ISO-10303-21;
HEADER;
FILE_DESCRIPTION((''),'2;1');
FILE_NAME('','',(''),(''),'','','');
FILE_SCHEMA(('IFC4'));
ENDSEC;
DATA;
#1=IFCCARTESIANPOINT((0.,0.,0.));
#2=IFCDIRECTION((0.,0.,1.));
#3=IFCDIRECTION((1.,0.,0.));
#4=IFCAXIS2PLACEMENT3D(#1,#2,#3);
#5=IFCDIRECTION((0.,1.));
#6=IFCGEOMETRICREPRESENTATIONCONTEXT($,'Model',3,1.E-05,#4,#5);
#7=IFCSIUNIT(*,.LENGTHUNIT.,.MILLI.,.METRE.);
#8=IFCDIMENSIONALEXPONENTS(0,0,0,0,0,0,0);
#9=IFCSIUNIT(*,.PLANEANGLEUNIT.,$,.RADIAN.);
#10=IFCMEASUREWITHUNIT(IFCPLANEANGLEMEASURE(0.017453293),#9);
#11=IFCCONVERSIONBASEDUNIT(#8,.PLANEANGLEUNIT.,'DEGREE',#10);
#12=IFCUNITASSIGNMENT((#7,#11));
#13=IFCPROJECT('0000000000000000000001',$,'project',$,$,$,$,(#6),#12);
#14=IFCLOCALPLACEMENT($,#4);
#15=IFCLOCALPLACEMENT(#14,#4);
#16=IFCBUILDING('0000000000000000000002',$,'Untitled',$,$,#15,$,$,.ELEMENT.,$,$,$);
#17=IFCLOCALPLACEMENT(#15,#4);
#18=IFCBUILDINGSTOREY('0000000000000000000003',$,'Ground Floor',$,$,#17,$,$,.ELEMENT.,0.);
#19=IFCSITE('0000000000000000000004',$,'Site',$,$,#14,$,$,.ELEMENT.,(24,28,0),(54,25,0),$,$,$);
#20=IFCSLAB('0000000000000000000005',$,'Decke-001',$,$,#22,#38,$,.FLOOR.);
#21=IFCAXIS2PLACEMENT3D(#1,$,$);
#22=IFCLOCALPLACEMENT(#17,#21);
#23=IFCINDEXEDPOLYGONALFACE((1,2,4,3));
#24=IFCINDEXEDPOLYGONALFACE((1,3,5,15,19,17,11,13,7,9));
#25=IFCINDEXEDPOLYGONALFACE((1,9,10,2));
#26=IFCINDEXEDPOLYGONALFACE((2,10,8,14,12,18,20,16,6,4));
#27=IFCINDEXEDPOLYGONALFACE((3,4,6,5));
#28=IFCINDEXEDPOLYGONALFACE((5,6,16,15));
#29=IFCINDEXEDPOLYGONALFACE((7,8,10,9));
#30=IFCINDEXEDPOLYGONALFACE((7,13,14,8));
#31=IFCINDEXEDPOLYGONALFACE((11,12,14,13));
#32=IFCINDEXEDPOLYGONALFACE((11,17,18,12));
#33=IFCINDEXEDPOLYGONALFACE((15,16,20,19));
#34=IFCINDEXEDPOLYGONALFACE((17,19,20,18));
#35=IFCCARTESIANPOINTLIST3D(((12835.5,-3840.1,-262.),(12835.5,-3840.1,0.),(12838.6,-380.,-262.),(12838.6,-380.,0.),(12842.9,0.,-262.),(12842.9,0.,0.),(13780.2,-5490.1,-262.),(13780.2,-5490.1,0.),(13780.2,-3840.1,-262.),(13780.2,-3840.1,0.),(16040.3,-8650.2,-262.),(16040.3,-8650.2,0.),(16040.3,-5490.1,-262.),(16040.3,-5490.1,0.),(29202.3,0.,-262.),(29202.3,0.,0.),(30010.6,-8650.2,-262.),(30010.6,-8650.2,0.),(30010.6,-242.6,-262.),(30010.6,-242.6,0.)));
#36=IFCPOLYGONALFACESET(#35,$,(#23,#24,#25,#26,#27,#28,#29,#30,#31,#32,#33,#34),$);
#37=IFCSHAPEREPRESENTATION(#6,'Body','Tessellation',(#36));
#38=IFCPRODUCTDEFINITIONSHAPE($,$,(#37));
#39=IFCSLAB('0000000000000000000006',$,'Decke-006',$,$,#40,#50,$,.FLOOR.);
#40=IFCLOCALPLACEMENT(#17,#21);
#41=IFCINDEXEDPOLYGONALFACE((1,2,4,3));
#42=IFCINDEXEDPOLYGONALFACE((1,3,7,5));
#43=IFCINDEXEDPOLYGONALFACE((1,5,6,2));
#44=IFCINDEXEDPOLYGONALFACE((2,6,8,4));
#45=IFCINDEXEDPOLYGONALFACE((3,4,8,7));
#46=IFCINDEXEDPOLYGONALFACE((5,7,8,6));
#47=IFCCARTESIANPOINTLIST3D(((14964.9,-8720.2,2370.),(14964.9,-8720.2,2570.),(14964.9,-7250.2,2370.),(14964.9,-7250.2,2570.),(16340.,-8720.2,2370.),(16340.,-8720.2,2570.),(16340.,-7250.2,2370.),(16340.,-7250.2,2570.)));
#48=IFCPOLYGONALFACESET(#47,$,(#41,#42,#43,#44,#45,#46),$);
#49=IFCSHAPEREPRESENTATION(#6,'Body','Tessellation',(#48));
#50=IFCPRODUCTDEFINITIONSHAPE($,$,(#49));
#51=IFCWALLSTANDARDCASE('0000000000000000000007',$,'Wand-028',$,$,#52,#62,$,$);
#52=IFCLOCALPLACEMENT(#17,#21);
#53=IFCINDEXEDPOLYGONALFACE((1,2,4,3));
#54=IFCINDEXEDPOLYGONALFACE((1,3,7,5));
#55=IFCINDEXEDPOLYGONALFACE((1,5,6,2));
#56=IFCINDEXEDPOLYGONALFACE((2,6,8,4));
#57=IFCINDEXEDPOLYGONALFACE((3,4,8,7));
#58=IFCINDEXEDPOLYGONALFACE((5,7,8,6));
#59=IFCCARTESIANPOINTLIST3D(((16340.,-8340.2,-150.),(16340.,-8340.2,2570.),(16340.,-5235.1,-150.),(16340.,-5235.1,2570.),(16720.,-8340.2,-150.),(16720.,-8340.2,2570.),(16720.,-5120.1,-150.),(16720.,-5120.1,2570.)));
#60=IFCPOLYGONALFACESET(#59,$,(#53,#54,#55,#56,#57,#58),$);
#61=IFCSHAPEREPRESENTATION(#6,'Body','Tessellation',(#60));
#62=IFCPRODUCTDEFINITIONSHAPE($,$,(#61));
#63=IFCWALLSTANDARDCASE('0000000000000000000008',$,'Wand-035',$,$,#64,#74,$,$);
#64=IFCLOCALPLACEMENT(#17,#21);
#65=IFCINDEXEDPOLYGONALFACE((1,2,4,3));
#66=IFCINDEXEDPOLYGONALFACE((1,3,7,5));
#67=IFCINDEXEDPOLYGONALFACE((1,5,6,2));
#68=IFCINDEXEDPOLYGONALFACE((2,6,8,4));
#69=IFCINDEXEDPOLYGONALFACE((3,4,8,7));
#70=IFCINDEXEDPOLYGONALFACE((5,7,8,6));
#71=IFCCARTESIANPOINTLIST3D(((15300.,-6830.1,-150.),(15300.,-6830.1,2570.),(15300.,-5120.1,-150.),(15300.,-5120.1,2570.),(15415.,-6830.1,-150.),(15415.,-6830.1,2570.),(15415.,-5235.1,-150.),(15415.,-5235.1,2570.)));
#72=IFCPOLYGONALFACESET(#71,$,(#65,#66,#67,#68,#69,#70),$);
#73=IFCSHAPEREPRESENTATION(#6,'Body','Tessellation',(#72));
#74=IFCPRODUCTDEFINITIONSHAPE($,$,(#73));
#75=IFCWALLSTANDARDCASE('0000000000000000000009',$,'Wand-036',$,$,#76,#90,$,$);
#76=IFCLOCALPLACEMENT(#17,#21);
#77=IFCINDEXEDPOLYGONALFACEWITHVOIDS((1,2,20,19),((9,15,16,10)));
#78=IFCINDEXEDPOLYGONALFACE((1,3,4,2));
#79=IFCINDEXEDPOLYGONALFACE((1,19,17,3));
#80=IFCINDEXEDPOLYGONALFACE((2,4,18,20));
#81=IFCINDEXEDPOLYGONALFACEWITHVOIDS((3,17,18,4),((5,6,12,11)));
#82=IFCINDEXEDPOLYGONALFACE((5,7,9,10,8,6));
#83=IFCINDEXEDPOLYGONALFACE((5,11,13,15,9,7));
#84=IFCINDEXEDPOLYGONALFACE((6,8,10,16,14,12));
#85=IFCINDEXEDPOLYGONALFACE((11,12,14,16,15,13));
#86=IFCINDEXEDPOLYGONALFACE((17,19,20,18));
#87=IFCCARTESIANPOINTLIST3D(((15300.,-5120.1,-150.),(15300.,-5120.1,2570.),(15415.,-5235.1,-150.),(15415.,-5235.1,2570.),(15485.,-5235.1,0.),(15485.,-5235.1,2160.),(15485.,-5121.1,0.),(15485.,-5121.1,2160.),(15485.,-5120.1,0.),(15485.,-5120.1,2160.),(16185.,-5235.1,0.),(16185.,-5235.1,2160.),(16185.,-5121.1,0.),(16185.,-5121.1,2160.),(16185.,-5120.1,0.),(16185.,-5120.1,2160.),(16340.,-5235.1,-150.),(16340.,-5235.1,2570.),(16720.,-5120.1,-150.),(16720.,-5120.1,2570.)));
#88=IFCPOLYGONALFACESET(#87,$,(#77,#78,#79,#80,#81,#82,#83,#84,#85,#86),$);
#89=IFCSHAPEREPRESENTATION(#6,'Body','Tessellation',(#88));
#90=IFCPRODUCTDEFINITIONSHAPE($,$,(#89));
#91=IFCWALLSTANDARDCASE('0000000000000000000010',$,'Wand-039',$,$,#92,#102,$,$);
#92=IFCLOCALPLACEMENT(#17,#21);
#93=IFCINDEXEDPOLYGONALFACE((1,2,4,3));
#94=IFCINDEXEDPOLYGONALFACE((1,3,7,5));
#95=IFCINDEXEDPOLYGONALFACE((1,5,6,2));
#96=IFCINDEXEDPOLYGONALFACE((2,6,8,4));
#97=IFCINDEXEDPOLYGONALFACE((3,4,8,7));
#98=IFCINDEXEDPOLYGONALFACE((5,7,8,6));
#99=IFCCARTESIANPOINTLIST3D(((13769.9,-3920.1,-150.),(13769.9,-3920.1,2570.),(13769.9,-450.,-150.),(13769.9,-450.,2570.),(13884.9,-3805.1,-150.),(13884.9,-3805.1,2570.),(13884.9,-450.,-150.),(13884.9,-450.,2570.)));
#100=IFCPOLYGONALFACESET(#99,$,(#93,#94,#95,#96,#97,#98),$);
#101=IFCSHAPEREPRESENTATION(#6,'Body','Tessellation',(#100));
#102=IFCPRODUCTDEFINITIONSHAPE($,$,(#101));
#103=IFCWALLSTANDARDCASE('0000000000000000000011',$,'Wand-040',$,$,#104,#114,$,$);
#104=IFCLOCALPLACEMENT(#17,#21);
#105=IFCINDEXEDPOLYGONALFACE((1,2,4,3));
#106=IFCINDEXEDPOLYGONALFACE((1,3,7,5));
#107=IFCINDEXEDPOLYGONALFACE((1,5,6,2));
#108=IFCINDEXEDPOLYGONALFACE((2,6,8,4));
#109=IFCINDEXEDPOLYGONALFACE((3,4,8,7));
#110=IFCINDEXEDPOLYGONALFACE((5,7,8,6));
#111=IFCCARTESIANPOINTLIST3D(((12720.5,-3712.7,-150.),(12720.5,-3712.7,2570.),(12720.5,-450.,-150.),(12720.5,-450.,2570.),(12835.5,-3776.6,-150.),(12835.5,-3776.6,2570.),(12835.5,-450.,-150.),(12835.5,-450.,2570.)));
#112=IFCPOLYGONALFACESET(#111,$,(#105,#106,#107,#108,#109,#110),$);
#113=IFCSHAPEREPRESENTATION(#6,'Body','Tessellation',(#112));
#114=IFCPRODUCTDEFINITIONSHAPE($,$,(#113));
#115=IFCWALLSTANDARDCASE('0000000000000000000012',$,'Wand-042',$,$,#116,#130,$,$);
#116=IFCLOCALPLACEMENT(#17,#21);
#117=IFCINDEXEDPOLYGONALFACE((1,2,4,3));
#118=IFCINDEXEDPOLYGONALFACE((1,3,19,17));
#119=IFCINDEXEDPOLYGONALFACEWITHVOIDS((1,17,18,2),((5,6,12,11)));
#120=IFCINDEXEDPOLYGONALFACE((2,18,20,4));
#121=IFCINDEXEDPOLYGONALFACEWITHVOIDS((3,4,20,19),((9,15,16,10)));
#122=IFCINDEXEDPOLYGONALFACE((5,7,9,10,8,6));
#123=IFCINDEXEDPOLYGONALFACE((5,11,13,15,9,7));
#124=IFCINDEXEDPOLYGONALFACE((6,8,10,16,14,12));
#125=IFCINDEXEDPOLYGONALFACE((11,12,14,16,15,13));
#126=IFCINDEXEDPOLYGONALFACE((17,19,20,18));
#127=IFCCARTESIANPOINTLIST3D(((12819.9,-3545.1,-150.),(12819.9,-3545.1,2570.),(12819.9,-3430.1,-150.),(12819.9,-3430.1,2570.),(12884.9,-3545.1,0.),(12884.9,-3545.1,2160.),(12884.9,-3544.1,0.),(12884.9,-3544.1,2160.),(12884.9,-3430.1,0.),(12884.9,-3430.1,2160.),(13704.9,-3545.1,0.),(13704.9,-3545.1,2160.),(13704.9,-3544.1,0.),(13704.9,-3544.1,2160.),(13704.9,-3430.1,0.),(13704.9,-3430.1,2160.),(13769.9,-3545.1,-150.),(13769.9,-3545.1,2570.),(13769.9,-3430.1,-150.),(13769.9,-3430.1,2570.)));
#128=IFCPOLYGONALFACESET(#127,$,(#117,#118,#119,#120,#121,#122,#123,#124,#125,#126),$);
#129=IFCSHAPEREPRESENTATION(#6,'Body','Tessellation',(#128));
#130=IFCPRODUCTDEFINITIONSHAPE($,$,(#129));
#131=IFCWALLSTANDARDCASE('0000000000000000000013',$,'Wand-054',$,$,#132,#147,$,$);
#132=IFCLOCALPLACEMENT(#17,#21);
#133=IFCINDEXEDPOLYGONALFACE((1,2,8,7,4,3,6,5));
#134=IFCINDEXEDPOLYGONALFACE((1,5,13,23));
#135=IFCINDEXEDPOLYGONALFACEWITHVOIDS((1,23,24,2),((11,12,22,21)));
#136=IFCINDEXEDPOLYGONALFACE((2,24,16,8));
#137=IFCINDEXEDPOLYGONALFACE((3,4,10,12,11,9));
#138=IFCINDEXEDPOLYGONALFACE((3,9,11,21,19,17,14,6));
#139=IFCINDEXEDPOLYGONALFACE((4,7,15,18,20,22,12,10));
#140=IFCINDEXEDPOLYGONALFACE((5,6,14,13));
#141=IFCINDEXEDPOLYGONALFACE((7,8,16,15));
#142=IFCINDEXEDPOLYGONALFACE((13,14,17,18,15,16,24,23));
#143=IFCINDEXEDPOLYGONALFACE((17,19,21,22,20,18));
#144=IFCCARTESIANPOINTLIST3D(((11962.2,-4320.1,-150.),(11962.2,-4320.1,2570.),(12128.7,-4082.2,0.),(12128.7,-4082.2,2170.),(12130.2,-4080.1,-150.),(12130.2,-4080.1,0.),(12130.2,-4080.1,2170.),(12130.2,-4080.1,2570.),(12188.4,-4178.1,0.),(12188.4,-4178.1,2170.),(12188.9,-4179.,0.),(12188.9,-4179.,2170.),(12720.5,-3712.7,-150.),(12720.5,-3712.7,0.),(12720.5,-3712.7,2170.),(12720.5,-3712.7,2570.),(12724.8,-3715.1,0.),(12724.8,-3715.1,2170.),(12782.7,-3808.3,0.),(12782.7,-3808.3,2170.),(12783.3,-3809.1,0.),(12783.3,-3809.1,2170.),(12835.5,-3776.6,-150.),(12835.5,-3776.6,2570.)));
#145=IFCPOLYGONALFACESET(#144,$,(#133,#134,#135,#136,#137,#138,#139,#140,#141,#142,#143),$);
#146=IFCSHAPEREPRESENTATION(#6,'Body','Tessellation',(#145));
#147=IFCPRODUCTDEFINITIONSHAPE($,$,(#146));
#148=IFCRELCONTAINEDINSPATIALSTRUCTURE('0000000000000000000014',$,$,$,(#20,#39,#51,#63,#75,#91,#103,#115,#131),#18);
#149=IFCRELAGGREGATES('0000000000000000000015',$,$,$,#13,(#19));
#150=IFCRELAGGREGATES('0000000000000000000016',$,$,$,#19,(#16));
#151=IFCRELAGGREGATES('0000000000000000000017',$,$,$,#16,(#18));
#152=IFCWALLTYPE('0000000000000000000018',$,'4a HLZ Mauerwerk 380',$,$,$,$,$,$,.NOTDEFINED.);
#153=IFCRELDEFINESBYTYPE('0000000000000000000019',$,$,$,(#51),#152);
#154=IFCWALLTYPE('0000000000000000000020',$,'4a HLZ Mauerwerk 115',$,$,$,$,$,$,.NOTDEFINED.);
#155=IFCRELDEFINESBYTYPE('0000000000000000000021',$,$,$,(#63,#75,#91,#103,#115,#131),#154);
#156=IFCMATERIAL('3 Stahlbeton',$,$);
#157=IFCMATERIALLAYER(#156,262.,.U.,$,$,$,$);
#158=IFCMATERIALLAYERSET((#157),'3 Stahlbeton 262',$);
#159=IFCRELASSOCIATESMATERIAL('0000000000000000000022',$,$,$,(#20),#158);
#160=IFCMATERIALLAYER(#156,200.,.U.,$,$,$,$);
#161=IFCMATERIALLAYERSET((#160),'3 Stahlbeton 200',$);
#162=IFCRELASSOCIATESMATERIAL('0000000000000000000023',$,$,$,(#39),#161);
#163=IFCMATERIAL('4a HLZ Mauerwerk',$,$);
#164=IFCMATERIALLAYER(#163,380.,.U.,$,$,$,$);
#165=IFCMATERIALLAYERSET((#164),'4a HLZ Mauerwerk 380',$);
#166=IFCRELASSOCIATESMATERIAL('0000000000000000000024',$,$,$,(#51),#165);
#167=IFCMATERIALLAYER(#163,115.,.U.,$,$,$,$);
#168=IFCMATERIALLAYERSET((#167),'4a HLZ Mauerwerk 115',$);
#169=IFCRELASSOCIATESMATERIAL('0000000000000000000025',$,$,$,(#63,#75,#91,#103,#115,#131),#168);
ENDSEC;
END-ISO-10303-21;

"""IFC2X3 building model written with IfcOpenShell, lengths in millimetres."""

from ifc_helpers import new_model, entity, si_unit, converted_unit, direction, frame, origin_with_axes, origin_2d_with_axis, place, context, project, spatial, polyline, rectangle, outline, extrude, material, layer, layer_set, layer_usage, type_object, element, save


model = new_model("IFC2X3")

# Units and contexts
model_context = context("Model", 3, precision=1e-05, world=origin_with_axes(), true_north=direction((0.0, 1.0)))
ifc_project = project(units=[si_unit("LENGTHUNIT", "METRE", prefix="MILLI"), converted_unit("PLANEANGLEUNIT", "DEGREE", entity("IfcPlaneAngleMeasure", 0.017453293), si_unit("PLANEANGLEUNIT", "RADIAN"), dimensions=[0, 0, 0, 0, 0, 0, 0])], contexts=[model_context])

# Site, building, storey
site_placement = place(None, origin_with_axes())
site = spatial("IfcSite", under=ifc_project, at=site_placement, Name="Site", CompositionType="ELEMENT", RefLatitude=(24, 28, 0), RefLongitude=(54, 25, 0))
building_placement = place(site_placement, origin_with_axes())
building = spatial("IfcBuilding", under=site, at=building_placement, Name="Untitled", CompositionType="ELEMENT")
storey_placement = place(building_placement, origin_with_axes())
storey = spatial("IfcBuildingStorey", under=building, at=storey_placement, Name="Ground Floor", CompositionType="ELEMENT", Elevation=0.0)

# Slabs
ifc_material_1 = material(Name="3 Stahlbeton")
ifc_layer_1 = layer(ifc_material_1, 262.0, ventilated="UNKNOWN")
ifc_layer_set_1 = layer_set([ifc_layer_1], Name="3 Stahlbeton 262")
ifc_layer_usage_1 = layer_usage(ifc_layer_set_1, "AXIS3", "NEGATIVE", 262.0)
slab_1_placement = place(storey_placement, frame((12842.9, 0.0, -262.0), z_axis=(0.0, 0.0, 1.0), x_axis=(1.0, 0.0, 0.0)))
element("IfcSlab", 1, at=slab_1_placement, inside=storey, material=ifc_layer_usage_1, Name="Decke-001", PredefinedType="FLOOR", context=model_context, shape_type="SweptSolid", body=[
    extrude(outline(polyline([(0.0, 0.0), (-4.3, -380.0), (-7.4, -3840.1), (937.3, -3840.1), (937.3, -5490.1), (3197.4, -5490.1), (3197.4, -8650.2), (17167.7, -8650.2), (17167.7, -242.6), (16359.4, 0.0), (0.0, 0.0)])), origin_with_axes(), (0.0, 0.0, 1.0), 262.0),
])
ifc_layer_2 = layer(ifc_material_1, 200.0, ventilated="UNKNOWN")
ifc_layer_set_2 = layer_set([ifc_layer_2], Name="3 Stahlbeton 200")
ifc_layer_usage_2 = layer_usage(ifc_layer_set_2, "AXIS3", "NEGATIVE", 200.0)
slab_2_placement = place(storey_placement, frame((14964.9, -7250.2, 2370.0), z_axis=(0.0, 0.0, 1.0), x_axis=(1.0, 0.0, 0.0)))
element("IfcSlab", 2, at=slab_2_placement, inside=storey, material=ifc_layer_usage_2, Name="Decke-006", PredefinedType="FLOOR", context=model_context, shape_type="SweptSolid", body=[
    extrude(outline(polyline([(0.0, 0.0), (0.0, -1470.0), (1375.1, -1470.0), (1375.1, 0.0), (0.0, 0.0)])), origin_with_axes(), (0.0, 0.0, 1.0), 200.0),
])

# Shared definitions
ifc_material_2 = material(Name="4a HLZ Mauerwerk")
ifc_layer_3 = layer(ifc_material_2, 380.0, ventilated="UNKNOWN")
ifc_layer_set_3 = layer_set([ifc_layer_3], Name="4a HLZ Mauerwerk 380")
wall_type_1 = type_object("IfcWallType", Name="4a HLZ Mauerwerk 380", PredefinedType="NOTDEFINED")

# Walls
ifc_layer_usage_3 = layer_usage(ifc_layer_set_3, "AXIS2", "NEGATIVE", 0.0)
wall_1_placement = place(storey_placement, frame((16340.0, -8720.2, -150.0), z_axis=(0.0, 0.0, 1.0), x_axis=(0.0, 1.0, 0.0)))
element("IfcWallStandardCase", 3, at=wall_1_placement, inside=storey, type_object=wall_type_1, material=ifc_layer_usage_3, Name="Wand-028", context=model_context, shape_type="SweptSolid", body=[
    extrude(outline(polyline([(380.0, -380.0), (3600.1, -380.0), (3485.1, 0.0), (380.0, 0.0), (380.0, -380.0)])), origin_with_axes(), (0.0, 0.0, 1.0), 2720.0),
])
ifc_layer_4 = layer(ifc_material_2, 115.0, ventilated="UNKNOWN")
ifc_layer_set_4 = layer_set([ifc_layer_4], Name="4a HLZ Mauerwerk 115")
ifc_layer_usage_4 = layer_usage(ifc_layer_set_4, "AXIS2", "NEGATIVE", 0.0)
wall_type_2 = type_object("IfcWallType", Name="4a HLZ Mauerwerk 115", PredefinedType="NOTDEFINED")
wall_2_placement = place(storey_placement, frame((15300.0, -6830.1, -150.0), z_axis=(0.0, 0.0, 1.0), x_axis=(0.0, 1.0, 0.0)))
element("IfcWallStandardCase", 4, at=wall_2_placement, inside=storey, type_object=wall_type_2, material=ifc_layer_usage_4, Name="Wand-035", context=model_context, shape_type="SweptSolid", body=[
    extrude(outline(polyline([(0.0, -115.0), (1595.0, -115.0), (1710.0, 0.0), (0.0, 0.0), (0.0, -115.0)])), origin_with_axes(), (0.0, 0.0, 1.0), 2720.0),
])

# Wall, opening
ifc_layer_usage_5 = layer_usage(ifc_layer_set_4, "AXIS2", "NEGATIVE", 0.0)
wall_3_placement = place(storey_placement, frame((15300.0, -5120.1, -150.0), z_axis=(0.0, 0.0, 1.0), x_axis=(1.0, 0.0, 0.0)))
wall_3 = element("IfcWallStandardCase", 5, at=wall_3_placement, inside=storey, type_object=wall_type_2, material=ifc_layer_usage_5, Name="Wand-036", context=model_context, shape_type="SweptSolid", body=[
    extrude(outline(polyline([(115.0, -115.0), (1040.0, -115.0), (1420.0, 0.0), (0.0, 0.0), (115.0, -115.0)])), origin_with_axes(), (0.0, 0.0, 1.0), 2720.0),
])
opening_1_placement = place(wall_3_placement, frame((535.0, 0.0, 150.0), z_axis=(0.0, 0.0, 1.0), x_axis=(1.0, 0.0, 0.0)))
element("IfcOpeningElement", 6, at=opening_1_placement, cuts=wall_3, context=model_context, shape_type="SweptSolid", body=[
    extrude(rectangle(XDim=700.0, YDim=2160.0, at=origin_2d_with_axis()), frame((0.0, 231.0, 1080.0), z_axis=(0.0, -1.0, 0.0), x_axis=(1.0, 0.0, 0.0)), (0.0, 0.0, 1.0), 232.0),
    extrude(rectangle(XDim=700.0, YDim=2160.0, at=origin_2d_with_axis()), frame((0.0, -231.0, 1080.0), z_axis=(0.0, 1.0, 0.0), x_axis=(1.0, 0.0, 0.0)), (0.0, 0.0, 1.0), 232.0),
])

# Walls
ifc_layer_usage_6 = layer_usage(ifc_layer_set_4, "AXIS2", "NEGATIVE", 0.0)
wall_4_placement = place(storey_placement, frame((13769.9, -3920.1, -150.0), z_axis=(0.0, 0.0, 1.0), x_axis=(0.0, 1.0, 0.0)))
element("IfcWallStandardCase", 7, at=wall_4_placement, inside=storey, type_object=wall_type_2, material=ifc_layer_usage_6, Name="Wand-039", context=model_context, shape_type="SweptSolid", body=[
    extrude(outline(polyline([(115.0, -115.0), (3470.1, -115.0), (3470.1, 0.0), (0.0, 0.0), (115.0, -115.0)])), origin_with_axes(), (0.0, 0.0, 1.0), 2720.0),
])
ifc_layer_usage_7 = layer_usage(ifc_layer_set_4, "AXIS2", "POSITIVE", 0.0)
wall_5_placement = place(storey_placement, frame((12720.5, -450.0, -150.0), z_axis=(0.0, 0.0, 1.0), x_axis=(0.0, -1.0, 0.0)))
element("IfcWallStandardCase", 8, at=wall_5_placement, inside=storey, type_object=wall_type_2, material=ifc_layer_usage_7, Name="Wand-040", context=model_context, shape_type="SweptSolid", body=[
    extrude(outline(polyline([(0.0, 0.0), (3262.7, 0.0), (3326.6, 115.0), (0.0, 115.0), (0.0, 0.0)])), origin_with_axes(), (0.0, 0.0, 1.0), 2720.0),
])

# Walls, openings
ifc_layer_usage_8 = layer_usage(ifc_layer_set_4, "AXIS2", "NEGATIVE", 0.0)
wall_6_placement = place(storey_placement, frame((12819.9, -3430.1, -150.0), z_axis=(0.0, 0.0, 1.0), x_axis=(1.0, 0.0, 0.0)))
wall_6 = element("IfcWallStandardCase", 9, at=wall_6_placement, inside=storey, type_object=wall_type_2, material=ifc_layer_usage_8, Name="Wand-042", context=model_context, shape_type="SweptSolid", body=[
    extrude(outline(polyline([(0.0, -115.0), (950.0, -115.0), (950.0, 0.0), (0.0, 0.0), (0.0, -115.0)])), origin_with_axes(), (0.0, 0.0, 1.0), 2720.0),
])
opening_2_placement = place(wall_6_placement, frame((475.0, 0.0, 150.0), z_axis=(0.0, 0.0, 1.0), x_axis=(1.0, 0.0, 0.0)))
element("IfcOpeningElement", 10, at=opening_2_placement, cuts=wall_6, context=model_context, shape_type="SweptSolid", body=[
    extrude(rectangle(XDim=820.0, YDim=2160.0, at=origin_2d_with_axis()), frame((0.0, -346.0, 1080.0), z_axis=(0.0, 1.0, 0.0), x_axis=(1.0, 0.0, 0.0)), (0.0, 0.0, 1.0), 232.0),
    extrude(rectangle(XDim=820.0, YDim=2160.0, at=origin_2d_with_axis()), frame((0.0, 116.0, 1080.0), z_axis=(0.0, -1.0, 0.0), x_axis=(1.0, 0.0, 0.0)), (0.0, 0.0, 1.0), 232.0),
])
ifc_layer_usage_9 = layer_usage(ifc_layer_set_4, "AXIS2", "POSITIVE", 0.0)
wall_7_placement = place(storey_placement, frame((12720.5, -3712.7, -150.0), z_axis=(0.0, 0.0, 1.0), x_axis=(-0.849031, -0.528343, 0.0)))
wall_7 = element("IfcWallStandardCase", 11, at=wall_7_placement, inside=storey, type_object=wall_type_2, material=ifc_layer_usage_9, Name="Wand-054", context=model_context, shape_type="SweptSolid", body=[
    extrude(outline(polyline([(0.0, 0.0), (695.3, 0.0), (964.7, 115.0), (-63.9, 115.0), (0.0, 0.0)])), origin_with_axes(), (0.0, 0.0, 1.0), 2720.0),
])
opening_3_placement = place(wall_7_placement, frame((347.6, 0.0, 150.0), z_axis=(0.0, 0.0, 1.0), x_axis=(1.0, 0.0, 0.0)))
element("IfcOpeningElement", 12, at=opening_3_placement, cuts=wall_7, context=model_context, shape_type="SweptSolid", body=[
    extrude(rectangle(XDim=700.0, YDim=2170.0, at=origin_2d_with_axis()), frame((0.0, 346.0, 1085.0), z_axis=(0.0, -1.0, 0.0), x_axis=(1.0, 0.0, 0.0)), (0.0, 0.0, 1.0), 232.0),
    extrude(rectangle(XDim=700.0, YDim=2170.0, at=origin_2d_with_axis()), frame((0.0, -116.0, 1085.0), z_axis=(0.0, 1.0, 0.0), x_axis=(1.0, 0.0, 0.0)), (0.0, 0.0, 1.0), 232.0),
])

save(model, "model.ifc")
